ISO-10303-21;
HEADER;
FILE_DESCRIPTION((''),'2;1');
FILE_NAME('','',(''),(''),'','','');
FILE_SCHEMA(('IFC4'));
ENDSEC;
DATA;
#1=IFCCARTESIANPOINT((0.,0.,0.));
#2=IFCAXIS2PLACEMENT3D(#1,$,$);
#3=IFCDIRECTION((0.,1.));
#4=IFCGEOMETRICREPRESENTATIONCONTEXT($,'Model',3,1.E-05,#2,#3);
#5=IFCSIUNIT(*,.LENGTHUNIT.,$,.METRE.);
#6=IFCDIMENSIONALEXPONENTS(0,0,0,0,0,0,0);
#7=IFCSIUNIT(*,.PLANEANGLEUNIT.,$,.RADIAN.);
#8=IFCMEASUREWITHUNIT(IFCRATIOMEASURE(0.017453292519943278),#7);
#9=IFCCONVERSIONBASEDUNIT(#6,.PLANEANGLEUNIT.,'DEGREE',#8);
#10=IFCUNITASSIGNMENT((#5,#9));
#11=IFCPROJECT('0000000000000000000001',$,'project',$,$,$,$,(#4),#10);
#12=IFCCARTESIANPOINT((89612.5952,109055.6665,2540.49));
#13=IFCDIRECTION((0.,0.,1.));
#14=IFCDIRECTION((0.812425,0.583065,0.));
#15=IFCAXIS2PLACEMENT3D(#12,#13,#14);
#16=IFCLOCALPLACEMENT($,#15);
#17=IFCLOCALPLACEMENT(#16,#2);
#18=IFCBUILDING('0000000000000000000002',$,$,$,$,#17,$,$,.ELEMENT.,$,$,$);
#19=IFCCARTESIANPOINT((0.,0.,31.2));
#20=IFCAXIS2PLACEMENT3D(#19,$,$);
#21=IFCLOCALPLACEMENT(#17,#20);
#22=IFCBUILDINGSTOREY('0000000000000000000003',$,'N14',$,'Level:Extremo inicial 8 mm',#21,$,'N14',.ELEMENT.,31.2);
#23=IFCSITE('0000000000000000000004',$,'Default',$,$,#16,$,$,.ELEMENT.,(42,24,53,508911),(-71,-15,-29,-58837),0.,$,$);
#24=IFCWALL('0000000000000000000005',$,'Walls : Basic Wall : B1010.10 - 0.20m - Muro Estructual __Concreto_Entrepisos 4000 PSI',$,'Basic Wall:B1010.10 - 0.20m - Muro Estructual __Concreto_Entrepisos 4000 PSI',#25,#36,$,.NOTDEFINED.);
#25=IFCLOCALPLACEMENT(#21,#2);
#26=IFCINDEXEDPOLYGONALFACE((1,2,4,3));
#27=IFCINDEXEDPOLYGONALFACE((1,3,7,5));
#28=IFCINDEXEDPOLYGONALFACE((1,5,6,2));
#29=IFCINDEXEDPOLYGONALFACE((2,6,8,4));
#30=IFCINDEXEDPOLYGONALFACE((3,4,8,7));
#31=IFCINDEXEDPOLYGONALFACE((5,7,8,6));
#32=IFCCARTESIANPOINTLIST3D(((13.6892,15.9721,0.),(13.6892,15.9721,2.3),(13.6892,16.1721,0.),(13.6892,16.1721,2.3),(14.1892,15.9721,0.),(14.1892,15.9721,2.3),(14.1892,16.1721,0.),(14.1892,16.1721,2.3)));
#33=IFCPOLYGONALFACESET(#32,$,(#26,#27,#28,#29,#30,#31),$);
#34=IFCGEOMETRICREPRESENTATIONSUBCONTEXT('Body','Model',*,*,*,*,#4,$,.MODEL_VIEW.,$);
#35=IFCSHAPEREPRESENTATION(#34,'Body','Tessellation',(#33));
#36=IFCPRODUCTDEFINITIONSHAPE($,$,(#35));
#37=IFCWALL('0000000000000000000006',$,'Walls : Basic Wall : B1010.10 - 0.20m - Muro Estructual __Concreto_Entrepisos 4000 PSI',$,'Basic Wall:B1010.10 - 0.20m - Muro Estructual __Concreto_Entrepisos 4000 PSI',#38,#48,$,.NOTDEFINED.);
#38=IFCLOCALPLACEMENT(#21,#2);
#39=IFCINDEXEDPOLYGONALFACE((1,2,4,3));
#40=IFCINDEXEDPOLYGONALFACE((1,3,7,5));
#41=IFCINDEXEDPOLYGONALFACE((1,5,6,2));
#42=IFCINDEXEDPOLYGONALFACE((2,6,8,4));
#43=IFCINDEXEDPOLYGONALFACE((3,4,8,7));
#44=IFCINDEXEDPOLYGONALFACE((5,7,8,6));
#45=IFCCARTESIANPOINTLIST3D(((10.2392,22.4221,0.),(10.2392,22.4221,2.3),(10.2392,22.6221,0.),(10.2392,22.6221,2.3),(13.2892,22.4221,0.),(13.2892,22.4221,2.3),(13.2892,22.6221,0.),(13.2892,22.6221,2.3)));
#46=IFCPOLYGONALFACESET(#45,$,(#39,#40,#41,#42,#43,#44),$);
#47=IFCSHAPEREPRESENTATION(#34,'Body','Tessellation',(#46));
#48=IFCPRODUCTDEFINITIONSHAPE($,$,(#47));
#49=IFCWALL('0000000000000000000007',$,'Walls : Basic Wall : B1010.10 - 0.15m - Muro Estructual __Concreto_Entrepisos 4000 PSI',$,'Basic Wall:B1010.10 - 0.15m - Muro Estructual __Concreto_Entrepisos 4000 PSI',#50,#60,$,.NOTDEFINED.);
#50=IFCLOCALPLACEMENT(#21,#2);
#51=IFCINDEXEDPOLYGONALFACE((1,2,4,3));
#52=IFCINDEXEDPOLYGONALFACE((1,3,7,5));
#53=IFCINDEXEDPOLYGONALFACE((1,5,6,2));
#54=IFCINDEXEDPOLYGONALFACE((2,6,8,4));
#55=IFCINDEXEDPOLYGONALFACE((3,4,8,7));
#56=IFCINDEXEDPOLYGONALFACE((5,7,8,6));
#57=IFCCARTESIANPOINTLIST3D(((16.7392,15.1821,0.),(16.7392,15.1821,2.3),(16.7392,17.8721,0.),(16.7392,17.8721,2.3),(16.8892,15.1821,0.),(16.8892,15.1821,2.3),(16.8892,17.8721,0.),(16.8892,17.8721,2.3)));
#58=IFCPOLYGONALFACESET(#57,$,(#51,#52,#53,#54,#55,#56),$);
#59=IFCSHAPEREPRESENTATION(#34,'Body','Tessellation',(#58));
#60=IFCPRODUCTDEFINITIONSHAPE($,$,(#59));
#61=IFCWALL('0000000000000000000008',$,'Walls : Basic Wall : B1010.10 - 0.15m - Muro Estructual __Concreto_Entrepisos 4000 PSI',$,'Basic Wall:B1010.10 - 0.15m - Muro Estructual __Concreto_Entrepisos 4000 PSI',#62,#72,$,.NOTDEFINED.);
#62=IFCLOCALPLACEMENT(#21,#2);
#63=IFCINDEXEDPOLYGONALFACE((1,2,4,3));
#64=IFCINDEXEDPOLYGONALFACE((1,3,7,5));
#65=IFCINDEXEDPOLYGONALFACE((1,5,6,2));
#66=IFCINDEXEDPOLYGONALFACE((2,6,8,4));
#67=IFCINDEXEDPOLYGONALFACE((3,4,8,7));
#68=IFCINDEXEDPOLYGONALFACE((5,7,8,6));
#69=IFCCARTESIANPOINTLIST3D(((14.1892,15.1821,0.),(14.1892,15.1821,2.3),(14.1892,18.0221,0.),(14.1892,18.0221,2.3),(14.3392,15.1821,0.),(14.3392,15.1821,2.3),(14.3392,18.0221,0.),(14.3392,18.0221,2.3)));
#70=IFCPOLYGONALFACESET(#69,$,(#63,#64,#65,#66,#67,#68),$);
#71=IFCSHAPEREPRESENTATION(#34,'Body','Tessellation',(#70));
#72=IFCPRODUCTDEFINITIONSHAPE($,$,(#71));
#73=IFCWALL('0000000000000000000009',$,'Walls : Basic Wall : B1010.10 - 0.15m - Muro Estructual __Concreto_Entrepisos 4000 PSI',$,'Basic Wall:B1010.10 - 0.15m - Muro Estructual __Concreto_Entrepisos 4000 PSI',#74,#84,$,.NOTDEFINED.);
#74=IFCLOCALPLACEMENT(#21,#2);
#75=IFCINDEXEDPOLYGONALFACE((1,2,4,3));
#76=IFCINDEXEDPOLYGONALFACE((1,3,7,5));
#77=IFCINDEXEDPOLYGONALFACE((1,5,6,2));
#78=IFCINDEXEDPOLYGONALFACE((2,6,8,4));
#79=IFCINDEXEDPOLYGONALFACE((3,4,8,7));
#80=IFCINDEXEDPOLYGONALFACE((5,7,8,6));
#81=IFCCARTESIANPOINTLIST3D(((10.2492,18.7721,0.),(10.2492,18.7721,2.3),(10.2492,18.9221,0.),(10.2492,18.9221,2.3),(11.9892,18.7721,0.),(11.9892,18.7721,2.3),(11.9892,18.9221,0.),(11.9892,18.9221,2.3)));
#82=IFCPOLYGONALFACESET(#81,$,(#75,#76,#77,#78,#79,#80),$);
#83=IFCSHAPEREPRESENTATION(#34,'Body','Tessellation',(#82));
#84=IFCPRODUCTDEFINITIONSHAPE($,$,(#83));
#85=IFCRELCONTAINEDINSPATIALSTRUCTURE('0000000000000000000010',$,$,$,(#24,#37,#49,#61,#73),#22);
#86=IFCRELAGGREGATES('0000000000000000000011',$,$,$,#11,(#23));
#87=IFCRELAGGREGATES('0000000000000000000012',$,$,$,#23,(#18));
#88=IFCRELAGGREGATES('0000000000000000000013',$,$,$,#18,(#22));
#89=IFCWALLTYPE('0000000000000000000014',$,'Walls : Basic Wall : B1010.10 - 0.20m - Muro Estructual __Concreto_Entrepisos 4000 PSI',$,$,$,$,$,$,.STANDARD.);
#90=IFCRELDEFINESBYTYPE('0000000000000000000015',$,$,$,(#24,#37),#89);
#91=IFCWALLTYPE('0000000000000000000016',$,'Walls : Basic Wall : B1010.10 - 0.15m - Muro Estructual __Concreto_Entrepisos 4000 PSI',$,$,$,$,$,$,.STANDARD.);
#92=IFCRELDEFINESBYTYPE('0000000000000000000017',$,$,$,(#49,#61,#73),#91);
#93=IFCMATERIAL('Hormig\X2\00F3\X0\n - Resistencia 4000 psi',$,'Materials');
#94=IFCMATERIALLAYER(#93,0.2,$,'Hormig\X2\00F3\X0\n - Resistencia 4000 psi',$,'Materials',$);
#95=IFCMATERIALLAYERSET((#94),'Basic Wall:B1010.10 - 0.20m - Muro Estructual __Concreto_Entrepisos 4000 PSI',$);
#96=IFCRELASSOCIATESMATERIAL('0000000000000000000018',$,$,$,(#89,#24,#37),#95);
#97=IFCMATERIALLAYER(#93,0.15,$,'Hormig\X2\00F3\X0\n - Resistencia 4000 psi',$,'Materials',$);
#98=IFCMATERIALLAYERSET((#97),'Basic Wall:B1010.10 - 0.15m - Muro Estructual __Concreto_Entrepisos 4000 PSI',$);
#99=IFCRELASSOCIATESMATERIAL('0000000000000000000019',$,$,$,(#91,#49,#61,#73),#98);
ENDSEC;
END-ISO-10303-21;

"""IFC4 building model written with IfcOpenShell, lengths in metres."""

from ifc_helpers import new_model, entity, si_unit, converted_unit, direction, frame, frame_2d, origin, place, context, subcontext, project, spatial, rectangle, extrude, material, layer, layer_set, layer_usage, type_object, element, save


model = new_model("IFC4")

# Units and contexts
model_context = context("Model", 3, precision=1e-05, world=origin(), true_north=direction((0.0, 1.0)))
body_context = subcontext(model_context, "Body", "Model", "MODEL_VIEW")
ifc_project = project(units=[si_unit("LENGTHUNIT", "METRE"), converted_unit("PLANEANGLEUNIT", "DEGREE", entity("IfcRatioMeasure", 0.017453292519943278), si_unit("PLANEANGLEUNIT", "RADIAN"), dimensions=[0, 0, 0, 0, 0, 0, 0])], contexts=[model_context])

# Site, building, storey
site_placement = place(None, frame((89612.5952, 109055.6665, 2540.49), z_axis=(0.0, 0.0, 1.0), x_axis=(0.812425, 0.583065, 0.0)))
site = spatial("IfcSite", under=ifc_project, at=site_placement, Name="Default", CompositionType="ELEMENT", RefLatitude=(42, 24, 53, 508911), RefLongitude=(-71, -15, -29, -58837), RefElevation=0.0)
building_placement = place(site_placement, origin())
building = spatial("IfcBuilding", under=site, at=building_placement, CompositionType="ELEMENT")
storey_placement = place(building_placement, frame((0.0, 0.0, 31.2)))
storey = spatial("IfcBuildingStorey", under=building, at=storey_placement, Name="N14", ObjectType="Level:Extremo inicial 8 mm", LongName="N14", CompositionType="ELEMENT", Elevation=31.2)

# Walls
ifc_material_1 = material(Name="Hormigón - Resistencia 4000 psi", Category="Materials")
ifc_layer_1 = layer(ifc_material_1, 0.2, Name="Hormigón - Resistencia 4000 psi", Category="Materials")
ifc_layer_set_1 = layer_set([ifc_layer_1], Name="Basic Wall:B1010.10 - 0.20m - Muro Estructual __Concreto_Entrepisos 4000 PSI")
wall_type_1 = type_object("IfcWallType", Name="Walls : Basic Wall : B1010.10 - 0.20m - Muro Estructual __Concreto_Entrepisos 4000 PSI", PredefinedType="STANDARD", material=ifc_layer_set_1)
ifc_layer_usage_1 = layer_usage(ifc_layer_set_1, "AXIS2", "NEGATIVE", 0.1)
wall_1_placement = place(storey_placement, frame((13.6892, 16.0721, 0.0)))
element("IfcWall", 1, at=wall_1_placement, inside=storey, type_object=wall_type_1, material=ifc_layer_usage_1, Name="Walls : Basic Wall : B1010.10 - 0.20m - Muro Estructual __Concreto_Entrepisos 4000 PSI", ObjectType="Basic Wall:B1010.10 - 0.20m - Muro Estructual __Concreto_Entrepisos 4000 PSI", PredefinedType="NOTDEFINED", context=body_context, shape_type="SweptSolid", body=[
    extrude(rectangle(XDim=0.5, YDim=0.2, at=frame_2d((0.25, 0.0), x_axis=(-1.0, 0.0))), origin(), (0.0, 0.0, 1.0), 2.3),
])
ifc_layer_usage_2 = layer_usage(ifc_layer_set_1, "AXIS2", "POSITIVE", -0.1)
wall_2_placement = place(storey_placement, frame((10.2392, 22.5221, 0.0)))
element("IfcWall", 2, at=wall_2_placement, inside=storey, type_object=wall_type_1, material=ifc_layer_usage_2, Name="Walls : Basic Wall : B1010.10 - 0.20m - Muro Estructual __Concreto_Entrepisos 4000 PSI", ObjectType="Basic Wall:B1010.10 - 0.20m - Muro Estructual __Concreto_Entrepisos 4000 PSI", PredefinedType="NOTDEFINED", context=body_context, shape_type="SweptSolid", body=[
    extrude(rectangle(XDim=3.05, YDim=0.2, at=frame_2d((1.525, 0.0), x_axis=(-1.0, 0.0))), origin(), (0.0, 0.0, 1.0), 2.3),
])
ifc_layer_2 = layer(ifc_material_1, 0.15, Name="Hormigón - Resistencia 4000 psi", Category="Materials")
ifc_layer_set_2 = layer_set([ifc_layer_2], Name="Basic Wall:B1010.10 - 0.15m - Muro Estructual __Concreto_Entrepisos 4000 PSI")
ifc_layer_usage_3 = layer_usage(ifc_layer_set_2, "AXIS2", "NEGATIVE", 0.075)
wall_type_2 = type_object("IfcWallType", Name="Walls : Basic Wall : B1010.10 - 0.15m - Muro Estructual __Concreto_Entrepisos 4000 PSI", PredefinedType="STANDARD", material=ifc_layer_set_2)
wall_3_placement = place(storey_placement, frame((16.8142, 15.1821, 0.0), z_axis=(0.0, 0.0, 1.0), x_axis=(0.0, 1.0, 0.0)))
element("IfcWall", 3, at=wall_3_placement, inside=storey, type_object=wall_type_2, material=ifc_layer_usage_3, Name="Walls : Basic Wall : B1010.10 - 0.15m - Muro Estructual __Concreto_Entrepisos 4000 PSI", ObjectType="Basic Wall:B1010.10 - 0.15m - Muro Estructual __Concreto_Entrepisos 4000 PSI", PredefinedType="NOTDEFINED", context=body_context, shape_type="SweptSolid", body=[
    extrude(rectangle(XDim=2.69, YDim=0.15, at=frame_2d((1.345, 0.0), x_axis=(-1.0, 0.0))), origin(), (0.0, 0.0, 1.0), 2.3),
])
ifc_layer_usage_4 = layer_usage(ifc_layer_set_2, "AXIS2", "NEGATIVE", 0.075)
wall_4_placement = place(storey_placement, frame((14.2642, 15.1821, 0.0), z_axis=(0.0, 0.0, 1.0), x_axis=(0.0, 1.0, 0.0)))
element("IfcWall", 4, at=wall_4_placement, inside=storey, type_object=wall_type_2, material=ifc_layer_usage_4, Name="Walls : Basic Wall : B1010.10 - 0.15m - Muro Estructual __Concreto_Entrepisos 4000 PSI", ObjectType="Basic Wall:B1010.10 - 0.15m - Muro Estructual __Concreto_Entrepisos 4000 PSI", PredefinedType="NOTDEFINED", context=body_context, shape_type="SweptSolid", body=[
    extrude(rectangle(XDim=2.84, YDim=0.15, at=frame_2d((1.42, 0.0), x_axis=(-1.0, 0.0))), origin(), (0.0, 0.0, 1.0), 2.3),
])
ifc_layer_usage_5 = layer_usage(ifc_layer_set_2, "AXIS2", "NEGATIVE", 0.075)
wall_5_placement = place(storey_placement, frame((11.9892, 18.8471, 0.0), z_axis=(0.0, 0.0, 1.0), x_axis=(-1.0, 0.0, 0.0)))
element("IfcWall", 5, at=wall_5_placement, inside=storey, type_object=wall_type_2, material=ifc_layer_usage_5, Name="Walls : Basic Wall : B1010.10 - 0.15m - Muro Estructual __Concreto_Entrepisos 4000 PSI", ObjectType="Basic Wall:B1010.10 - 0.15m - Muro Estructual __Concreto_Entrepisos 4000 PSI", PredefinedType="NOTDEFINED", context=body_context, shape_type="SweptSolid", body=[
    extrude(rectangle(XDim=1.74, YDim=0.15, at=frame_2d((0.87, 0.0), x_axis=(-1.0, 0.0))), origin(), (0.0, 0.0, 1.0), 2.3),
])

save(model, "model.ifc")
